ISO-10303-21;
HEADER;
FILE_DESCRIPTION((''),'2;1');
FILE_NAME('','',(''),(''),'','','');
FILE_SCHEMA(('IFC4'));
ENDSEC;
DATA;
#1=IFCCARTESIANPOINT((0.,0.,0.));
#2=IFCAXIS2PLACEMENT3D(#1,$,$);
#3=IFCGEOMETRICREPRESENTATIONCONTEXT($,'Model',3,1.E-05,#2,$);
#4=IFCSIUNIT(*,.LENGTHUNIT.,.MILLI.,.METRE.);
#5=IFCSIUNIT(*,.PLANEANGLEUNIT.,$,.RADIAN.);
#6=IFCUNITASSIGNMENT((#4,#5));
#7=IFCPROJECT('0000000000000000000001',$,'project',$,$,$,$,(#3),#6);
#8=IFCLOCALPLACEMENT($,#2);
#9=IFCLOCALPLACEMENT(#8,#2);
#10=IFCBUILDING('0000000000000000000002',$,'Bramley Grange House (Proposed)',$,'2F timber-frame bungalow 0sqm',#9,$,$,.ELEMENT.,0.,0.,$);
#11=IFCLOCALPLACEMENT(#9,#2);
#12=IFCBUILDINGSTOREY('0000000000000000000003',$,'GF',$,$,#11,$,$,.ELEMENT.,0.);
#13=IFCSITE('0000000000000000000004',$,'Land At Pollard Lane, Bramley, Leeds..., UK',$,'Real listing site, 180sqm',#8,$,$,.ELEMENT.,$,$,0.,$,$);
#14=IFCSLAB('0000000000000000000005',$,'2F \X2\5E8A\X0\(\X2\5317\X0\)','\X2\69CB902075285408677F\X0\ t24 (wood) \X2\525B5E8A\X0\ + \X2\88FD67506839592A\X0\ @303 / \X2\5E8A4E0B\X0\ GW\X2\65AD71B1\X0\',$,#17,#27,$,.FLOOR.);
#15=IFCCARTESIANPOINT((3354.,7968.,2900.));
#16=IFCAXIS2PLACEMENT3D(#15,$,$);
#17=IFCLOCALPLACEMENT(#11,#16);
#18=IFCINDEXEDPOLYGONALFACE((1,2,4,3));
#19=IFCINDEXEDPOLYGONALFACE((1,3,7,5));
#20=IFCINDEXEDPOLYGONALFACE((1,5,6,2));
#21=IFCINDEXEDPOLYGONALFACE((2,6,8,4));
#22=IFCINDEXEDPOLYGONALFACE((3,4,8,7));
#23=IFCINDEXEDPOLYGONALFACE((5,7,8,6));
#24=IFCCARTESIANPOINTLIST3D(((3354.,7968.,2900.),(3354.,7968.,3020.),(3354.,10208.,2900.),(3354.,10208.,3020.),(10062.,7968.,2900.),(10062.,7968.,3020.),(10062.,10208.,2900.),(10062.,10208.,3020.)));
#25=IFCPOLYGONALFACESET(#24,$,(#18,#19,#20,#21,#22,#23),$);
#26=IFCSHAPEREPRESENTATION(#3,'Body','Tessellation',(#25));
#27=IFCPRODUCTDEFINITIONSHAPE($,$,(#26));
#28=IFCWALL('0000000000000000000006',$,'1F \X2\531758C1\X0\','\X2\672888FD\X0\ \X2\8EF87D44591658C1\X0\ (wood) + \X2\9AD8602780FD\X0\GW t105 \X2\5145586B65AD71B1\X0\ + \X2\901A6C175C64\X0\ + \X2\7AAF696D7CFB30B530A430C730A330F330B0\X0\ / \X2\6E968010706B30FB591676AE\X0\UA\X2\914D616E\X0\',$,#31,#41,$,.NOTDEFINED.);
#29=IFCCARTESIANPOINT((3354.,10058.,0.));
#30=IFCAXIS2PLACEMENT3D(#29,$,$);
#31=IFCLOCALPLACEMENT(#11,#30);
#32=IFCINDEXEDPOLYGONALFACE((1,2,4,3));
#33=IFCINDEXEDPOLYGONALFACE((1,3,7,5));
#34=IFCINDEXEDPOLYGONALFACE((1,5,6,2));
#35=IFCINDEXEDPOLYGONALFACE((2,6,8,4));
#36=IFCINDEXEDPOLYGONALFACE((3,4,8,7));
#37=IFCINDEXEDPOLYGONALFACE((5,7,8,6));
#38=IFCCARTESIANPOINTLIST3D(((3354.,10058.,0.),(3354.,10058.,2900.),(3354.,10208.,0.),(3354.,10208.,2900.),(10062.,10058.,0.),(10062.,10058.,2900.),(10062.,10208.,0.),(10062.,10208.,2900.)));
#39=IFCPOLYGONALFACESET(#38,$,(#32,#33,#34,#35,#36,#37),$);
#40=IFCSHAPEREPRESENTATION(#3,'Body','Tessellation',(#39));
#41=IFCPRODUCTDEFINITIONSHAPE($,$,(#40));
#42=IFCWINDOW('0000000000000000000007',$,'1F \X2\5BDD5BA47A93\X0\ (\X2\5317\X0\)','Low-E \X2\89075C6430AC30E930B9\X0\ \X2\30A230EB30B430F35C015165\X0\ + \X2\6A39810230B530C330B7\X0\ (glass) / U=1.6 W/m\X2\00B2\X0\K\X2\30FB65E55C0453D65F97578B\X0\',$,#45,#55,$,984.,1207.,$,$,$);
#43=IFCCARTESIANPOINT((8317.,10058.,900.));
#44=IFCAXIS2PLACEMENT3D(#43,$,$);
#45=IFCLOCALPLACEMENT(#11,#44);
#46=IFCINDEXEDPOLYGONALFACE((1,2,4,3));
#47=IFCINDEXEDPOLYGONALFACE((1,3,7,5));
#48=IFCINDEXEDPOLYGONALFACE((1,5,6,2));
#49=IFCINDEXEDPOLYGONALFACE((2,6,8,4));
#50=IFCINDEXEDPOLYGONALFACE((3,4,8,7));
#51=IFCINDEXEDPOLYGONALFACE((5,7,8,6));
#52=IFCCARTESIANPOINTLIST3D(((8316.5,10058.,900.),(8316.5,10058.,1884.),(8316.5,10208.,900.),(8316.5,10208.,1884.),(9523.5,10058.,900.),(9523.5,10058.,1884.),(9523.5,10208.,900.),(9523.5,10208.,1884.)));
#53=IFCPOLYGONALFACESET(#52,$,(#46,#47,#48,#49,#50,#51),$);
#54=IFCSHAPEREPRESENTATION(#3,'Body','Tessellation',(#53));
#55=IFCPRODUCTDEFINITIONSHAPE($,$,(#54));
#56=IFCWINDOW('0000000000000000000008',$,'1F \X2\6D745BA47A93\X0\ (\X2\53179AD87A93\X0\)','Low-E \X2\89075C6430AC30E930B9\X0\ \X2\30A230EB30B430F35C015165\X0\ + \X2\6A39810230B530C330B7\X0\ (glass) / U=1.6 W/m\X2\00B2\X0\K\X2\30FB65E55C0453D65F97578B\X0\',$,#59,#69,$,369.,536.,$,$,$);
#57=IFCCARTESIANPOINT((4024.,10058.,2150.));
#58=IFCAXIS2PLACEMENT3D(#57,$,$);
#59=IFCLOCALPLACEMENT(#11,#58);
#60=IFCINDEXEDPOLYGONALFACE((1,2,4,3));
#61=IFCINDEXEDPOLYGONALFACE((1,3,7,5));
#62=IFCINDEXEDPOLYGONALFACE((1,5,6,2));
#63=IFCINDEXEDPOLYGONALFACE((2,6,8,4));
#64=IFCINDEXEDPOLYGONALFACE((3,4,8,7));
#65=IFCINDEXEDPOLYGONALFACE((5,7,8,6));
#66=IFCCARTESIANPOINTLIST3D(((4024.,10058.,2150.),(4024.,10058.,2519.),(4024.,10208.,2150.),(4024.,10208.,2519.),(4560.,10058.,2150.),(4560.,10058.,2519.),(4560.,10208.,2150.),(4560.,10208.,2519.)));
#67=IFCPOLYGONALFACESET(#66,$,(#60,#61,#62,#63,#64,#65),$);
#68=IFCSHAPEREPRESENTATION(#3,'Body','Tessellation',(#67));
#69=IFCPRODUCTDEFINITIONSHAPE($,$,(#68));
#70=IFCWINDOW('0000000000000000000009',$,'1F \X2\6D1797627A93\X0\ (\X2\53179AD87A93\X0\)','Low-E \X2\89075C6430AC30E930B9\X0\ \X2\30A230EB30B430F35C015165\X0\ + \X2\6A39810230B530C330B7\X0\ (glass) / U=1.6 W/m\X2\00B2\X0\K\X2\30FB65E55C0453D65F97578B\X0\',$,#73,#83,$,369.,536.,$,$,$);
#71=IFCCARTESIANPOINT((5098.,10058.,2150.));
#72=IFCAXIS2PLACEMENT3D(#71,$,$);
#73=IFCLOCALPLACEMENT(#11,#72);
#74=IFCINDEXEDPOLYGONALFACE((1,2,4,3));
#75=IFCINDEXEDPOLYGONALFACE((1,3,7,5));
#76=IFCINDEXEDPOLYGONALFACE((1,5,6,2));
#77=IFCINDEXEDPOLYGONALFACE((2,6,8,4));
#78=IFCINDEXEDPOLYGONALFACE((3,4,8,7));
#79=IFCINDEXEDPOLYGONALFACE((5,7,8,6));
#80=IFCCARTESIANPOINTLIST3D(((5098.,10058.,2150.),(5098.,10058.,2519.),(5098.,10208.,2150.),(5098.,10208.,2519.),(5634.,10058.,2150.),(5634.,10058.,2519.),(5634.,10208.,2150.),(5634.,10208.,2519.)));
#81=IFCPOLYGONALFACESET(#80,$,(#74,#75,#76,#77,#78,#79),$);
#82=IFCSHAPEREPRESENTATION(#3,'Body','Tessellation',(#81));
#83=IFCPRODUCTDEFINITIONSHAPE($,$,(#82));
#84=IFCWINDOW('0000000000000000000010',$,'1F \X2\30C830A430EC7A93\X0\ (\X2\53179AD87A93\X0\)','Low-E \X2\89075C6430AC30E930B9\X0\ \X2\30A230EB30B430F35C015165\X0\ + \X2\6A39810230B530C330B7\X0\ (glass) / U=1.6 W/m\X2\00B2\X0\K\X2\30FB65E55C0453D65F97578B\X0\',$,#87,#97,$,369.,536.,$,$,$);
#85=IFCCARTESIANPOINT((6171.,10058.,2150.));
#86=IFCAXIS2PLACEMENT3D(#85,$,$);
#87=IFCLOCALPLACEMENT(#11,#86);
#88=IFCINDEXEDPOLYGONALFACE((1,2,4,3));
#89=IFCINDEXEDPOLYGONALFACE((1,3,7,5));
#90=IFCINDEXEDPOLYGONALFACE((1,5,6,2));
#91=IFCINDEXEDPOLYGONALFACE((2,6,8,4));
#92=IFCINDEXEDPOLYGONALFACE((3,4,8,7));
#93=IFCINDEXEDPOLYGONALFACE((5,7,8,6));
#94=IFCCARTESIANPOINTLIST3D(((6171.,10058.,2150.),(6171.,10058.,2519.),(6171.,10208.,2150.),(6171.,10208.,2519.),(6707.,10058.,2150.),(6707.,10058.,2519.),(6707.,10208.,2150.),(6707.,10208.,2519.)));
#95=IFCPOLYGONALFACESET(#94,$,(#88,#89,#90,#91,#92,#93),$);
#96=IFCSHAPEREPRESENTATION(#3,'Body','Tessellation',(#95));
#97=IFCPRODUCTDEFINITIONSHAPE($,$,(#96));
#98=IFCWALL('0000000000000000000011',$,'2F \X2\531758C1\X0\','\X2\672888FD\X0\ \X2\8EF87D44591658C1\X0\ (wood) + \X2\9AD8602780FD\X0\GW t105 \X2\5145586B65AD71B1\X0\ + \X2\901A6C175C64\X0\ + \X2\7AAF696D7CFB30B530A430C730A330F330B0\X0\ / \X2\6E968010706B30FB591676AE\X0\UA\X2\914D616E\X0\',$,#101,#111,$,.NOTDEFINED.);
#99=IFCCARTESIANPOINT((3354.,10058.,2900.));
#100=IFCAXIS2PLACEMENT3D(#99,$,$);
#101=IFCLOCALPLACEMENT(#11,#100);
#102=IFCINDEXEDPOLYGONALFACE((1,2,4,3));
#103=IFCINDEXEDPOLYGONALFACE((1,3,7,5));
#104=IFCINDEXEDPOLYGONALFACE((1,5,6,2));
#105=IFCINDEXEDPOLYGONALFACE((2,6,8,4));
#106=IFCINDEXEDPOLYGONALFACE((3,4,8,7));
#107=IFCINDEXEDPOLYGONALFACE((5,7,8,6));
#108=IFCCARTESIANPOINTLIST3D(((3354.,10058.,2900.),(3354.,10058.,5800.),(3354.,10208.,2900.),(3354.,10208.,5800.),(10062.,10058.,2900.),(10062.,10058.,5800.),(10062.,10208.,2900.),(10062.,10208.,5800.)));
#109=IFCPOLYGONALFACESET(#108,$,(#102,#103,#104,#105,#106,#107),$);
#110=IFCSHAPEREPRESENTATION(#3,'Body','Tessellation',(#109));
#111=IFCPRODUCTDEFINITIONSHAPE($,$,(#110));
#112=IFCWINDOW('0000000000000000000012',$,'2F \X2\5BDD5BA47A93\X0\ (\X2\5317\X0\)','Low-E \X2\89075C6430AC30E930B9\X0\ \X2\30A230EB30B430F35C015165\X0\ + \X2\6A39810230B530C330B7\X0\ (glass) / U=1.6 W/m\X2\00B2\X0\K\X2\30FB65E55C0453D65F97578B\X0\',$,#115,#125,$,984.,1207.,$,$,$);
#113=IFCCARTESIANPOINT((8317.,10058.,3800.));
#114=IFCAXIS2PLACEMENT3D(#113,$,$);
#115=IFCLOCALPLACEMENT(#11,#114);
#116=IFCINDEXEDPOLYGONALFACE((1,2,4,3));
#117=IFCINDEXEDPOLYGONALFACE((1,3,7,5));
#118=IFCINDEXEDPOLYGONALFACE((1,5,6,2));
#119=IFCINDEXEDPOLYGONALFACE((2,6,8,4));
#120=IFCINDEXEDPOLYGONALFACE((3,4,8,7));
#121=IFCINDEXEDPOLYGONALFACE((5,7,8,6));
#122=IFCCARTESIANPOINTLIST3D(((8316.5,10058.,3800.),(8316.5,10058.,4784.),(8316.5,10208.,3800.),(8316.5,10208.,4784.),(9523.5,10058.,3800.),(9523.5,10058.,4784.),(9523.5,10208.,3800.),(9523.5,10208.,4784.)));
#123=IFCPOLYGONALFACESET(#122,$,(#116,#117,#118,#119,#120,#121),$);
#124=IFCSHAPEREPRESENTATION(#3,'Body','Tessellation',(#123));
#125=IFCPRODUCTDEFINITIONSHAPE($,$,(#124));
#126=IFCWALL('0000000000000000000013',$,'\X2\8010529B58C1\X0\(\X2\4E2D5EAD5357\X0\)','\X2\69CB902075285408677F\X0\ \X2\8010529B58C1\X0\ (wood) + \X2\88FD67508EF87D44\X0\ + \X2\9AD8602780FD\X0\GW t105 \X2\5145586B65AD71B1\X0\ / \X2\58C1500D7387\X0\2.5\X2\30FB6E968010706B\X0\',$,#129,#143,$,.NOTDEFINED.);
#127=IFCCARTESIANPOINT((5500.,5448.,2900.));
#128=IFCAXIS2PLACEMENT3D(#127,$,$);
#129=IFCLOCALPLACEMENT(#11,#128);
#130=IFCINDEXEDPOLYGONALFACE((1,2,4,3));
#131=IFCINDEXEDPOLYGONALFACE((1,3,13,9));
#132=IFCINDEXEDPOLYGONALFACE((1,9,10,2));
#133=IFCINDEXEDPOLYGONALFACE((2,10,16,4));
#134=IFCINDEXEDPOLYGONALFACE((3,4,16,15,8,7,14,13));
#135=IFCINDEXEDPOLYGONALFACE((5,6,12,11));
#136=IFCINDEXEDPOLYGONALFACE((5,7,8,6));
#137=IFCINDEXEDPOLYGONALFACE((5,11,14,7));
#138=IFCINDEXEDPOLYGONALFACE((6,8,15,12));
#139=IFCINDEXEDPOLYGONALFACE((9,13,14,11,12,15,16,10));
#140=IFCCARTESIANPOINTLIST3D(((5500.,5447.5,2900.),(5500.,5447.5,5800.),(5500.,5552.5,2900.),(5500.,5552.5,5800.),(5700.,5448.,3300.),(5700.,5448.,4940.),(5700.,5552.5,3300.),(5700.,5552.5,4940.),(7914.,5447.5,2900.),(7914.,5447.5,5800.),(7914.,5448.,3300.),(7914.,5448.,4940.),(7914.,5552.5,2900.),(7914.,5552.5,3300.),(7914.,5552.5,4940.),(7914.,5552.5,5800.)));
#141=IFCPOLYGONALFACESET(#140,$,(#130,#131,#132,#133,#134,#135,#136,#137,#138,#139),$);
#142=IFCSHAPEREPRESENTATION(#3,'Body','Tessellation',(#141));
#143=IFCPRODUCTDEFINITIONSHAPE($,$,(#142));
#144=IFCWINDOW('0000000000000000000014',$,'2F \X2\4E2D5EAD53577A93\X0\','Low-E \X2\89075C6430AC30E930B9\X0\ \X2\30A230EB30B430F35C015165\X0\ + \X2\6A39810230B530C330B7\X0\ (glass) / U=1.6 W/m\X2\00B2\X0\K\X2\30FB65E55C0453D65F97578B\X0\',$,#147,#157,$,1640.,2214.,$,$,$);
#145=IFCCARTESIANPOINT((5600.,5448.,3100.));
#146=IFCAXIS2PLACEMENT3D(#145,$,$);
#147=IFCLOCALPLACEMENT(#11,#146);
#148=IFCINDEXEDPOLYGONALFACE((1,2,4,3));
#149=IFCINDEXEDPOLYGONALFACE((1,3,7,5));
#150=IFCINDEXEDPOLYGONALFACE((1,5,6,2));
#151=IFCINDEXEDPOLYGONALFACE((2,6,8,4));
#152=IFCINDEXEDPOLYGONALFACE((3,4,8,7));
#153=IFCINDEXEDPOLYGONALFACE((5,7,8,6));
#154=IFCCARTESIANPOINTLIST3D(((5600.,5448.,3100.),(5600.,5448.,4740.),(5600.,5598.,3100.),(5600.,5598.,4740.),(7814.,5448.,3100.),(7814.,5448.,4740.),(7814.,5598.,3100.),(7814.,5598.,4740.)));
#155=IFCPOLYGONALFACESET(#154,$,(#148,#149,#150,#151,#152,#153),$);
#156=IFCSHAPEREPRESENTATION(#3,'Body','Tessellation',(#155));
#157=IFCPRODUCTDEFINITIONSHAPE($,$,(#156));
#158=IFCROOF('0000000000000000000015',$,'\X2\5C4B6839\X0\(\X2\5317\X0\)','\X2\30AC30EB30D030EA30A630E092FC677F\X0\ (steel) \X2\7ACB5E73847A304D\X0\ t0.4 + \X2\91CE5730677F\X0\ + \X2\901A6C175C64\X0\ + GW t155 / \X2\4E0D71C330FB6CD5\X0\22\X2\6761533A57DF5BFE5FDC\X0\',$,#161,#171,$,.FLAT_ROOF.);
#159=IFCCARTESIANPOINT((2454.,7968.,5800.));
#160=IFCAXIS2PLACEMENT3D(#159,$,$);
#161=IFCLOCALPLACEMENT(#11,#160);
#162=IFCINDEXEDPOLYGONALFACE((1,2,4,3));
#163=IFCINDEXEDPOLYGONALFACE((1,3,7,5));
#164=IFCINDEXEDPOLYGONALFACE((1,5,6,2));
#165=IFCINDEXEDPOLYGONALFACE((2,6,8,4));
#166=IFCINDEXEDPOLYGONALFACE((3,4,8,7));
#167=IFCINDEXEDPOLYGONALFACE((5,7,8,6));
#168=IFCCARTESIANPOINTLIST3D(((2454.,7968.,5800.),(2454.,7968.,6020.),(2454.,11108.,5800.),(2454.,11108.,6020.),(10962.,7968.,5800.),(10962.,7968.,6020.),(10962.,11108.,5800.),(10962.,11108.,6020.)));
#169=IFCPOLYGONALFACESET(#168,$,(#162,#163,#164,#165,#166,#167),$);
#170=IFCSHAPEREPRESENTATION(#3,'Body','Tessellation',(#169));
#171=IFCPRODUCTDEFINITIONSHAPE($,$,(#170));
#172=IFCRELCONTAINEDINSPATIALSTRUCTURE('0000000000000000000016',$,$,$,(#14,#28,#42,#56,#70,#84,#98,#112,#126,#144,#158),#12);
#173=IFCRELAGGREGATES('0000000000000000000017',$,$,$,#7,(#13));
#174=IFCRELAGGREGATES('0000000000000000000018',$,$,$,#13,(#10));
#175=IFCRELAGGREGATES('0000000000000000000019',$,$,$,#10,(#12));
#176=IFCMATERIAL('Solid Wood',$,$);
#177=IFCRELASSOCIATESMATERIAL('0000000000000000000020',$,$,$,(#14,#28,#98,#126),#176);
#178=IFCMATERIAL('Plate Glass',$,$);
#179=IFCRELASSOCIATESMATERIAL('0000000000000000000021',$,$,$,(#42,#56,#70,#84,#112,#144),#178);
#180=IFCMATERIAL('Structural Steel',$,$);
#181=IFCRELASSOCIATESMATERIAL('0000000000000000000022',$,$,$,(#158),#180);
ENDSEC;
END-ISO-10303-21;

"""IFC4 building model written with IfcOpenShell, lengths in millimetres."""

from ifc_helpers import new_model, si_unit, frame, frame_2d, origin, place, context, project, spatial, rectangle, extrude, material, element, fill, save


model = new_model("IFC4")

# Units and contexts
model_context = context("Model", 3, precision=1e-05, world=origin())
ifc_project = project(units=[si_unit("LENGTHUNIT", "METRE", prefix="MILLI"), si_unit("PLANEANGLEUNIT", "RADIAN")], contexts=[model_context])

# Site, building, storey
site_placement = place(None, origin())
site = spatial("IfcSite", under=ifc_project, at=site_placement, Name="Land At Pollard Lane, Bramley, Leeds..., UK", ObjectType="Real listing site, 180sqm", CompositionType="ELEMENT", RefElevation=0.0)
building_placement = place(site_placement, origin())
building = spatial("IfcBuilding", under=site, at=building_placement, Name="Bramley Grange House (Proposed)", ObjectType="2F timber-frame bungalow 0sqm", CompositionType="ELEMENT", ElevationOfRefHeight=0.0, ElevationOfTerrain=0.0)
storey_placement = place(building_placement, origin())
storey = spatial("IfcBuildingStorey", under=building, at=storey_placement, Name="GF", CompositionType="ELEMENT", Elevation=0.0)

# Slab
ifc_material_1 = material(Name="Solid Wood")
slab_1_placement = place(storey_placement, frame((3354.0, 7968.0, 2900.0)))
element("IfcSlab", 1, at=slab_1_placement, inside=storey, material=ifc_material_1, Name="2F 床(北)", Description="構造用合板 t24 (wood) 剛床 + 製材根太 @303 / 床下 GW断熱", PredefinedType="FLOOR", context=model_context, shape_type="SweptSolid", body=[
    extrude(rectangle(XDim=6708.0, YDim=2240.0, at=frame_2d((3354.0, 1120.0))), frame((3354.0, 7968.0, 2900.0)), (0.0, 0.0, 1.0), 120.0),
])

# Wall, openings, windows
wall_1_placement = place(storey_placement, frame((3354.0, 10058.0, 0.0)))
wall_1 = element("IfcWall", 2, at=wall_1_placement, inside=storey, material=ifc_material_1, Name="1F 北壁", Description="木製 軸組外壁 (wood) + 高性能GW t105 充填断熱 + 通気層 + 窯業系サイディング / 準耐火・外皮UA配慮", PredefinedType="NOTDEFINED", context=model_context, shape_type="SweptSolid", body=[
    extrude(rectangle(XDim=6708.0, YDim=150.0, at=frame_2d((3354.0, 75.0))), frame((3354.0, 10058.0, 0.0)), (0.0, 0.0, 1.0), 2900.0),
])
opening_1_placement = place(storey_placement, frame((8317.0, 10058.0, 900.0)))
opening_1 = element("IfcOpeningElement", 3, at=opening_1_placement, cuts=wall_1, PredefinedType="NOTDEFINED", context=model_context, shape_type="SweptSolid", body=[
    extrude(rectangle(XDim=1207.0, YDim=150.0, at=frame_2d((603.0, 75.0))), frame((8317.0, 10058.0, 900.0)), (0.0, 0.0, 1.0), 984.0),
])
opening_2_placement = place(storey_placement, frame((4024.0, 10058.0, 2150.0)))
opening_2 = element("IfcOpeningElement", 4, at=opening_2_placement, cuts=wall_1, PredefinedType="NOTDEFINED", context=model_context, shape_type="SweptSolid", body=[
    extrude(rectangle(XDim=536.0, YDim=150.0, at=frame_2d((268.0, 75.0))), frame((4024.0, 10058.0, 2150.0)), (0.0, 0.0, 1.0), 369.0),
])
opening_3_placement = place(storey_placement, frame((5098.0, 10058.0, 2150.0)))
opening_3 = element("IfcOpeningElement", 5, at=opening_3_placement, cuts=wall_1, PredefinedType="NOTDEFINED", context=model_context, shape_type="SweptSolid", body=[
    extrude(rectangle(XDim=536.0, YDim=150.0, at=frame_2d((268.0, 75.0))), frame((5098.0, 10058.0, 2150.0)), (0.0, 0.0, 1.0), 369.0),
])
opening_4_placement = place(storey_placement, frame((6171.0, 10058.0, 2150.0)))
opening_4 = element("IfcOpeningElement", 6, at=opening_4_placement, cuts=wall_1, PredefinedType="NOTDEFINED", context=model_context, shape_type="SweptSolid", body=[
    extrude(rectangle(XDim=536.0, YDim=150.0, at=frame_2d((268.0, 75.0))), frame((6171.0, 10058.0, 2150.0)), (0.0, 0.0, 1.0), 369.0),
])
ifc_material_2 = material(Name="Plate Glass")
window_1_placement = place(storey_placement, frame((8317.0, 10058.0, 900.0)))
window_1 = element("IfcWindow", 7, at=window_1_placement, inside=storey, material=ifc_material_2, Name="1F 寝室窓 (北)", Description="Low-E 複層ガラス アルゴン封入 + 樹脂サッシ (glass) / U=1.6 W/m²K・日射取得型", OverallHeight=984.0, OverallWidth=1207.0, context=model_context, shape_type="SweptSolid", body=[
    extrude(rectangle(XDim=1207.0, YDim=150.0, at=frame_2d((603.0, 75.0))), frame((8317.0, 10058.0, 900.0)), (0.0, 0.0, 1.0), 984.0),
])
fill(opening_1, window_1)
window_2_placement = place(storey_placement, frame((4024.0, 10058.0, 2150.0)))
window_2 = element("IfcWindow", 8, at=window_2_placement, inside=storey, material=ifc_material_2, Name="1F 浴室窓 (北高窓)", Description="Low-E 複層ガラス アルゴン封入 + 樹脂サッシ (glass) / U=1.6 W/m²K・日射取得型", OverallHeight=369.0, OverallWidth=536.0, context=model_context, shape_type="SweptSolid", body=[
    extrude(rectangle(XDim=536.0, YDim=150.0, at=frame_2d((268.0, 75.0))), frame((4024.0, 10058.0, 2150.0)), (0.0, 0.0, 1.0), 369.0),
])
fill(opening_2, window_2)
window_3_placement = place(storey_placement, frame((5098.0, 10058.0, 2150.0)))
window_3 = element("IfcWindow", 9, at=window_3_placement, inside=storey, material=ifc_material_2, Name="1F 洗面窓 (北高窓)", Description="Low-E 複層ガラス アルゴン封入 + 樹脂サッシ (glass) / U=1.6 W/m²K・日射取得型", OverallHeight=369.0, OverallWidth=536.0, context=model_context, shape_type="SweptSolid", body=[
    extrude(rectangle(XDim=536.0, YDim=150.0, at=frame_2d((268.0, 75.0))), frame((5098.0, 10058.0, 2150.0)), (0.0, 0.0, 1.0), 369.0),
])
fill(opening_3, window_3)
window_4_placement = place(storey_placement, frame((6171.0, 10058.0, 2150.0)))
window_4 = element("IfcWindow", 10, at=window_4_placement, inside=storey, material=ifc_material_2, Name="1F トイレ窓 (北高窓)", Description="Low-E 複層ガラス アルゴン封入 + 樹脂サッシ (glass) / U=1.6 W/m²K・日射取得型", OverallHeight=369.0, OverallWidth=536.0, context=model_context, shape_type="SweptSolid", body=[
    extrude(rectangle(XDim=536.0, YDim=150.0, at=frame_2d((268.0, 75.0))), frame((6171.0, 10058.0, 2150.0)), (0.0, 0.0, 1.0), 369.0),
])
fill(opening_4, window_4)

# Walls, openings, windows
wall_2_placement = place(storey_placement, frame((3354.0, 10058.0, 2900.0)))
wall_2 = element("IfcWall", 11, at=wall_2_placement, inside=storey, material=ifc_material_1, Name="2F 北壁", Description="木製 軸組外壁 (wood) + 高性能GW t105 充填断熱 + 通気層 + 窯業系サイディング / 準耐火・外皮UA配慮", PredefinedType="NOTDEFINED", context=model_context, shape_type="SweptSolid", body=[
    extrude(rectangle(XDim=6708.0, YDim=150.0, at=frame_2d((3354.0, 75.0))), frame((3354.0, 10058.0, 2900.0)), (0.0, 0.0, 1.0), 2900.0),
])
opening_5_placement = place(storey_placement, frame((8317.0, 10058.0, 3800.0)))
opening_5 = element("IfcOpeningElement", 12, at=opening_5_placement, cuts=wall_2, PredefinedType="NOTDEFINED", context=model_context, shape_type="SweptSolid", body=[
    extrude(rectangle(XDim=1207.0, YDim=150.0, at=frame_2d((603.0, 75.0))), frame((8317.0, 10058.0, 3800.0)), (0.0, 0.0, 1.0), 984.0),
])
window_5_placement = place(storey_placement, frame((8317.0, 10058.0, 3800.0)))
window_5 = element("IfcWindow", 13, at=window_5_placement, inside=storey, material=ifc_material_2, Name="2F 寝室窓 (北)", Description="Low-E 複層ガラス アルゴン封入 + 樹脂サッシ (glass) / U=1.6 W/m²K・日射取得型", OverallHeight=984.0, OverallWidth=1207.0, context=model_context, shape_type="SweptSolid", body=[
    extrude(rectangle(XDim=1207.0, YDim=150.0, at=frame_2d((603.0, 75.0))), frame((8317.0, 10058.0, 3800.0)), (0.0, 0.0, 1.0), 984.0),
])
fill(opening_5, window_5)
wall_3_placement = place(storey_placement, frame((5500.0, 5448.0, 2900.0)))
wall_3 = element("IfcWall", 14, at=wall_3_placement, inside=storey, material=ifc_material_1, Name="耐力壁(中庭南)", Description="構造用合板 耐力壁 (wood) + 製材軸組 + 高性能GW t105 充填断熱 / 壁倍率2.5・準耐火", PredefinedType="NOTDEFINED", context=model_context, shape_type="SweptSolid", body=[
    extrude(rectangle(XDim=2414.0, YDim=105.0, at=frame_2d((1207.0, 52.0))), frame((5500.0, 5448.0, 2900.0)), (0.0, 0.0, 1.0), 2900.0),
])
opening_6_placement = place(storey_placement, frame((5600.0, 5448.0, 3100.0)))
opening_6 = element("IfcOpeningElement", 15, at=opening_6_placement, cuts=wall_3, PredefinedType="NOTDEFINED", context=model_context, shape_type="SweptSolid", body=[
    extrude(rectangle(XDim=2214.0, YDim=150.0, at=frame_2d((1107.0, 75.0))), frame((5600.0, 5448.0, 3100.0)), (0.0, 0.0, 1.0), 1640.0),
])
window_6_placement = place(storey_placement, frame((5600.0, 5448.0, 3100.0)))
window_6 = element("IfcWindow", 16, at=window_6_placement, inside=storey, material=ifc_material_2, Name="2F 中庭南窓", Description="Low-E 複層ガラス アルゴン封入 + 樹脂サッシ (glass) / U=1.6 W/m²K・日射取得型", OverallHeight=1640.0, OverallWidth=2214.0, context=model_context, shape_type="SweptSolid", body=[
    extrude(rectangle(XDim=2214.0, YDim=150.0, at=frame_2d((1107.0, 75.0))), frame((5600.0, 5448.0, 3100.0)), (0.0, 0.0, 1.0), 1640.0),
])
fill(opening_6, window_6)

# Roof
ifc_material_3 = material(Name="Structural Steel")
for number, where, name in (
    (17, (2454.0, 7968.0, 5800.0), "屋根(北)"),
):
    element("IfcRoof", number, at=place(storey_placement, frame(where)), inside=storey, material=ifc_material_3, Name=name, Description="ガルバリウム鋼板 (steel) 立平葺き t0.4 + 野地板 + 通気層 + GW t155 / 不燃・法22条区域対応", PredefinedType="FLAT_ROOF", context=model_context, shape_type="SweptSolid", body=[
        extrude(rectangle(XDim=8508.0, YDim=3140.0, at=frame_2d((4254.0, 1570.0))), frame((2454.0, 7968.0, 5800.0)), (0.0, 0.0, 1.0), 220.0),
    ])

save(model, "model.ifc")
